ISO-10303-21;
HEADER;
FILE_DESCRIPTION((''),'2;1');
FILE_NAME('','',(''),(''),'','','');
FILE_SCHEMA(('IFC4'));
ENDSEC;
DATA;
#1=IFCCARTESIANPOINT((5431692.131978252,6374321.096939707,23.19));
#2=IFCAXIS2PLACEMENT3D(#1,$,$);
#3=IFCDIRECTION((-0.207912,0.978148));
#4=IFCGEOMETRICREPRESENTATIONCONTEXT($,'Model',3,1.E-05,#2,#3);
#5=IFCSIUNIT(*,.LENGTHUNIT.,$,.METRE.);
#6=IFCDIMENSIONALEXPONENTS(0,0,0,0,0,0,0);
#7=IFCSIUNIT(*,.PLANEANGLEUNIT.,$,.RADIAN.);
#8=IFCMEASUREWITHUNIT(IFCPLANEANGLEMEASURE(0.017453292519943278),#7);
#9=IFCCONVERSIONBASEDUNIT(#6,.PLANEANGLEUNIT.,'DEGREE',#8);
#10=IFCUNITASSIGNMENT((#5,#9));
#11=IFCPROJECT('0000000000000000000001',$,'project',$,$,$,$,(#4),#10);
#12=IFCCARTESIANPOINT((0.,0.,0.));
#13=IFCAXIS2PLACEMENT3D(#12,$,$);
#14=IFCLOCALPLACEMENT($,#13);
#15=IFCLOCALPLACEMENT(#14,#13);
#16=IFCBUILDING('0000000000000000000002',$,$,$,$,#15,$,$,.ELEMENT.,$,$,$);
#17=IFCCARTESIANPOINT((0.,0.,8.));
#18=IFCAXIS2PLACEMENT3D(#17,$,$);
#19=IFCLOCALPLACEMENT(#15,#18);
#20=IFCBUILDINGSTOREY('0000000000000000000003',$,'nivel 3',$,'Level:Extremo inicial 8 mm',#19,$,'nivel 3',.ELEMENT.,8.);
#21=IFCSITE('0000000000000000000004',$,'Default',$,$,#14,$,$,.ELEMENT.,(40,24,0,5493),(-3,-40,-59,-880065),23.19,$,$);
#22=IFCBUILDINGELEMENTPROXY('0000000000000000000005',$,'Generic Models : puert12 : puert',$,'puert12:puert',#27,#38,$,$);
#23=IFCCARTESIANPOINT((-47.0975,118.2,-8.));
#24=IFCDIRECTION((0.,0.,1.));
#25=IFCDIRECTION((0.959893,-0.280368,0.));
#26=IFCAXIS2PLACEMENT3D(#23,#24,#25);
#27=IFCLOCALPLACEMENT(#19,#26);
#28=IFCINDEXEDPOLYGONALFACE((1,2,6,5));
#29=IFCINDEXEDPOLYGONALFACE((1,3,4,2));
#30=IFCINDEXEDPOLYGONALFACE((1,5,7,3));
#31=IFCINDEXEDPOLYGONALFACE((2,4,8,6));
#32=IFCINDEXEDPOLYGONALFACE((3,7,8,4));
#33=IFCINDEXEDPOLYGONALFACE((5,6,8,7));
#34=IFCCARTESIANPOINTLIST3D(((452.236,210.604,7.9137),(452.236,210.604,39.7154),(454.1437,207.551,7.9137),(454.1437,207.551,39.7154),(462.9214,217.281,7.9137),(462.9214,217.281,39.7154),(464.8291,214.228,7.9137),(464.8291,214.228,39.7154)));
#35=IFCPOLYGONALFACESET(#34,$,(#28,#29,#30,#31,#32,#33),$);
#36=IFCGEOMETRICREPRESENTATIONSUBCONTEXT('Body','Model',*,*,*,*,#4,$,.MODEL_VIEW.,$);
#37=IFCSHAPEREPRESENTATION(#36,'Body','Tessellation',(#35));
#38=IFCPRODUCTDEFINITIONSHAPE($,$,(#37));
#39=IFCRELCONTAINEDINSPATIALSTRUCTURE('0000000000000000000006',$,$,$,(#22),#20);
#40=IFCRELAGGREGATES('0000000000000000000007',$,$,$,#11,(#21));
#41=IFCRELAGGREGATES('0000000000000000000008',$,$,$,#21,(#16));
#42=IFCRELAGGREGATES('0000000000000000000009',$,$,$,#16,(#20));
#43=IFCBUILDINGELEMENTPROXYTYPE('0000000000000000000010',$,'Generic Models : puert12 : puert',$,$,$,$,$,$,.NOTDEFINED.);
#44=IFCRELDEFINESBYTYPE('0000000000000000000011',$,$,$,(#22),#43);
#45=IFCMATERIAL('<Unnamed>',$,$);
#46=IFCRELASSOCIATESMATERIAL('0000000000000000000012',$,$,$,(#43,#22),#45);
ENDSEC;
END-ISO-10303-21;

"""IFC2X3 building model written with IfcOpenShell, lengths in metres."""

from ifc_helpers import new_model, entity, si_unit, converted_unit, direction, frame, frame_2d, origin, place, context, subcontext, project, spatial, rectangle, extrude, source, transform, mapped, material, type_object, type_shapes, element, save


model = new_model("IFC2X3")

# Units and contexts
model_context = context("Model", 3, precision=1e-05, world=frame((5431692.131978252, 6374321.096939707, 23.19)), true_north=direction((-0.207912, 0.978148)))
body_context = subcontext(model_context, "Body", "Model", "MODEL_VIEW")
ifc_project = project(units=[si_unit("LENGTHUNIT", "METRE"), converted_unit("PLANEANGLEUNIT", "DEGREE", entity("IfcPlaneAngleMeasure", 0.017453292519943278), si_unit("PLANEANGLEUNIT", "RADIAN"), dimensions=[0, 0, 0, 0, 0, 0, 0])], contexts=[model_context])

# Site, building, storey
site_placement = place(None, origin())
site = spatial("IfcSite", under=ifc_project, at=site_placement, Name="Default", CompositionType="ELEMENT", RefLatitude=(40, 24, 0, 5493), RefLongitude=(-3, -40, -59, -880065), RefElevation=23.19)
building_placement = place(site_placement, origin())
building = spatial("IfcBuilding", under=site, at=building_placement, CompositionType="ELEMENT")
storey_placement = place(building_placement, frame((0.0, 0.0, 8.0)))
storey = spatial("IfcBuildingStorey", under=building, at=storey_placement, Name="nivel 3", ObjectType="Level:Extremo inicial 8 mm", LongName="nivel 3", CompositionType="ELEMENT", Elevation=8.0)

# Building element proxy
ifc_material_1 = material(Name="<Unnamed>")
building_element_proxy_type = type_object("IfcBuildingElementProxyType", Name="Generic Models : puert12 : puert", PredefinedType="NOTDEFINED", material=ifc_material_1)
shared_shape = source(origin(), body_context, "Body", "SweptSolid", [
    extrude(rectangle(XDim=12.6, YDim=3.6, at=frame_2d((0.0, 0.0), x_axis=(1.0, 0.0))), frame((458.5325, 212.416, 7.9137), z_axis=(0.0, 0.0, 1.0), x_axis=(-0.848048, -0.529919, 0.0)), (0.0, 0.0, 1.0), 31.8017),
])
type_shapes(building_element_proxy_type, [shared_shape])
proxy_placement = place(storey_placement, frame((-47.0975, 118.2, -8.0), z_axis=(0.0, 0.0, 1.0), x_axis=(0.959893, -0.280368, 0.0)))
element("IfcBuildingElementProxy", 1, at=proxy_placement, inside=storey, type_object=building_element_proxy_type, material=ifc_material_1, Name="Generic Models : puert12 : puert", ObjectType="puert12:puert", context=body_context, shape_type="MappedRepresentation", body=[
    mapped(shared_shape, transform((0.0, 0.0, 0.0), scale=1.0)),
])

save(model, "model.ifc")
